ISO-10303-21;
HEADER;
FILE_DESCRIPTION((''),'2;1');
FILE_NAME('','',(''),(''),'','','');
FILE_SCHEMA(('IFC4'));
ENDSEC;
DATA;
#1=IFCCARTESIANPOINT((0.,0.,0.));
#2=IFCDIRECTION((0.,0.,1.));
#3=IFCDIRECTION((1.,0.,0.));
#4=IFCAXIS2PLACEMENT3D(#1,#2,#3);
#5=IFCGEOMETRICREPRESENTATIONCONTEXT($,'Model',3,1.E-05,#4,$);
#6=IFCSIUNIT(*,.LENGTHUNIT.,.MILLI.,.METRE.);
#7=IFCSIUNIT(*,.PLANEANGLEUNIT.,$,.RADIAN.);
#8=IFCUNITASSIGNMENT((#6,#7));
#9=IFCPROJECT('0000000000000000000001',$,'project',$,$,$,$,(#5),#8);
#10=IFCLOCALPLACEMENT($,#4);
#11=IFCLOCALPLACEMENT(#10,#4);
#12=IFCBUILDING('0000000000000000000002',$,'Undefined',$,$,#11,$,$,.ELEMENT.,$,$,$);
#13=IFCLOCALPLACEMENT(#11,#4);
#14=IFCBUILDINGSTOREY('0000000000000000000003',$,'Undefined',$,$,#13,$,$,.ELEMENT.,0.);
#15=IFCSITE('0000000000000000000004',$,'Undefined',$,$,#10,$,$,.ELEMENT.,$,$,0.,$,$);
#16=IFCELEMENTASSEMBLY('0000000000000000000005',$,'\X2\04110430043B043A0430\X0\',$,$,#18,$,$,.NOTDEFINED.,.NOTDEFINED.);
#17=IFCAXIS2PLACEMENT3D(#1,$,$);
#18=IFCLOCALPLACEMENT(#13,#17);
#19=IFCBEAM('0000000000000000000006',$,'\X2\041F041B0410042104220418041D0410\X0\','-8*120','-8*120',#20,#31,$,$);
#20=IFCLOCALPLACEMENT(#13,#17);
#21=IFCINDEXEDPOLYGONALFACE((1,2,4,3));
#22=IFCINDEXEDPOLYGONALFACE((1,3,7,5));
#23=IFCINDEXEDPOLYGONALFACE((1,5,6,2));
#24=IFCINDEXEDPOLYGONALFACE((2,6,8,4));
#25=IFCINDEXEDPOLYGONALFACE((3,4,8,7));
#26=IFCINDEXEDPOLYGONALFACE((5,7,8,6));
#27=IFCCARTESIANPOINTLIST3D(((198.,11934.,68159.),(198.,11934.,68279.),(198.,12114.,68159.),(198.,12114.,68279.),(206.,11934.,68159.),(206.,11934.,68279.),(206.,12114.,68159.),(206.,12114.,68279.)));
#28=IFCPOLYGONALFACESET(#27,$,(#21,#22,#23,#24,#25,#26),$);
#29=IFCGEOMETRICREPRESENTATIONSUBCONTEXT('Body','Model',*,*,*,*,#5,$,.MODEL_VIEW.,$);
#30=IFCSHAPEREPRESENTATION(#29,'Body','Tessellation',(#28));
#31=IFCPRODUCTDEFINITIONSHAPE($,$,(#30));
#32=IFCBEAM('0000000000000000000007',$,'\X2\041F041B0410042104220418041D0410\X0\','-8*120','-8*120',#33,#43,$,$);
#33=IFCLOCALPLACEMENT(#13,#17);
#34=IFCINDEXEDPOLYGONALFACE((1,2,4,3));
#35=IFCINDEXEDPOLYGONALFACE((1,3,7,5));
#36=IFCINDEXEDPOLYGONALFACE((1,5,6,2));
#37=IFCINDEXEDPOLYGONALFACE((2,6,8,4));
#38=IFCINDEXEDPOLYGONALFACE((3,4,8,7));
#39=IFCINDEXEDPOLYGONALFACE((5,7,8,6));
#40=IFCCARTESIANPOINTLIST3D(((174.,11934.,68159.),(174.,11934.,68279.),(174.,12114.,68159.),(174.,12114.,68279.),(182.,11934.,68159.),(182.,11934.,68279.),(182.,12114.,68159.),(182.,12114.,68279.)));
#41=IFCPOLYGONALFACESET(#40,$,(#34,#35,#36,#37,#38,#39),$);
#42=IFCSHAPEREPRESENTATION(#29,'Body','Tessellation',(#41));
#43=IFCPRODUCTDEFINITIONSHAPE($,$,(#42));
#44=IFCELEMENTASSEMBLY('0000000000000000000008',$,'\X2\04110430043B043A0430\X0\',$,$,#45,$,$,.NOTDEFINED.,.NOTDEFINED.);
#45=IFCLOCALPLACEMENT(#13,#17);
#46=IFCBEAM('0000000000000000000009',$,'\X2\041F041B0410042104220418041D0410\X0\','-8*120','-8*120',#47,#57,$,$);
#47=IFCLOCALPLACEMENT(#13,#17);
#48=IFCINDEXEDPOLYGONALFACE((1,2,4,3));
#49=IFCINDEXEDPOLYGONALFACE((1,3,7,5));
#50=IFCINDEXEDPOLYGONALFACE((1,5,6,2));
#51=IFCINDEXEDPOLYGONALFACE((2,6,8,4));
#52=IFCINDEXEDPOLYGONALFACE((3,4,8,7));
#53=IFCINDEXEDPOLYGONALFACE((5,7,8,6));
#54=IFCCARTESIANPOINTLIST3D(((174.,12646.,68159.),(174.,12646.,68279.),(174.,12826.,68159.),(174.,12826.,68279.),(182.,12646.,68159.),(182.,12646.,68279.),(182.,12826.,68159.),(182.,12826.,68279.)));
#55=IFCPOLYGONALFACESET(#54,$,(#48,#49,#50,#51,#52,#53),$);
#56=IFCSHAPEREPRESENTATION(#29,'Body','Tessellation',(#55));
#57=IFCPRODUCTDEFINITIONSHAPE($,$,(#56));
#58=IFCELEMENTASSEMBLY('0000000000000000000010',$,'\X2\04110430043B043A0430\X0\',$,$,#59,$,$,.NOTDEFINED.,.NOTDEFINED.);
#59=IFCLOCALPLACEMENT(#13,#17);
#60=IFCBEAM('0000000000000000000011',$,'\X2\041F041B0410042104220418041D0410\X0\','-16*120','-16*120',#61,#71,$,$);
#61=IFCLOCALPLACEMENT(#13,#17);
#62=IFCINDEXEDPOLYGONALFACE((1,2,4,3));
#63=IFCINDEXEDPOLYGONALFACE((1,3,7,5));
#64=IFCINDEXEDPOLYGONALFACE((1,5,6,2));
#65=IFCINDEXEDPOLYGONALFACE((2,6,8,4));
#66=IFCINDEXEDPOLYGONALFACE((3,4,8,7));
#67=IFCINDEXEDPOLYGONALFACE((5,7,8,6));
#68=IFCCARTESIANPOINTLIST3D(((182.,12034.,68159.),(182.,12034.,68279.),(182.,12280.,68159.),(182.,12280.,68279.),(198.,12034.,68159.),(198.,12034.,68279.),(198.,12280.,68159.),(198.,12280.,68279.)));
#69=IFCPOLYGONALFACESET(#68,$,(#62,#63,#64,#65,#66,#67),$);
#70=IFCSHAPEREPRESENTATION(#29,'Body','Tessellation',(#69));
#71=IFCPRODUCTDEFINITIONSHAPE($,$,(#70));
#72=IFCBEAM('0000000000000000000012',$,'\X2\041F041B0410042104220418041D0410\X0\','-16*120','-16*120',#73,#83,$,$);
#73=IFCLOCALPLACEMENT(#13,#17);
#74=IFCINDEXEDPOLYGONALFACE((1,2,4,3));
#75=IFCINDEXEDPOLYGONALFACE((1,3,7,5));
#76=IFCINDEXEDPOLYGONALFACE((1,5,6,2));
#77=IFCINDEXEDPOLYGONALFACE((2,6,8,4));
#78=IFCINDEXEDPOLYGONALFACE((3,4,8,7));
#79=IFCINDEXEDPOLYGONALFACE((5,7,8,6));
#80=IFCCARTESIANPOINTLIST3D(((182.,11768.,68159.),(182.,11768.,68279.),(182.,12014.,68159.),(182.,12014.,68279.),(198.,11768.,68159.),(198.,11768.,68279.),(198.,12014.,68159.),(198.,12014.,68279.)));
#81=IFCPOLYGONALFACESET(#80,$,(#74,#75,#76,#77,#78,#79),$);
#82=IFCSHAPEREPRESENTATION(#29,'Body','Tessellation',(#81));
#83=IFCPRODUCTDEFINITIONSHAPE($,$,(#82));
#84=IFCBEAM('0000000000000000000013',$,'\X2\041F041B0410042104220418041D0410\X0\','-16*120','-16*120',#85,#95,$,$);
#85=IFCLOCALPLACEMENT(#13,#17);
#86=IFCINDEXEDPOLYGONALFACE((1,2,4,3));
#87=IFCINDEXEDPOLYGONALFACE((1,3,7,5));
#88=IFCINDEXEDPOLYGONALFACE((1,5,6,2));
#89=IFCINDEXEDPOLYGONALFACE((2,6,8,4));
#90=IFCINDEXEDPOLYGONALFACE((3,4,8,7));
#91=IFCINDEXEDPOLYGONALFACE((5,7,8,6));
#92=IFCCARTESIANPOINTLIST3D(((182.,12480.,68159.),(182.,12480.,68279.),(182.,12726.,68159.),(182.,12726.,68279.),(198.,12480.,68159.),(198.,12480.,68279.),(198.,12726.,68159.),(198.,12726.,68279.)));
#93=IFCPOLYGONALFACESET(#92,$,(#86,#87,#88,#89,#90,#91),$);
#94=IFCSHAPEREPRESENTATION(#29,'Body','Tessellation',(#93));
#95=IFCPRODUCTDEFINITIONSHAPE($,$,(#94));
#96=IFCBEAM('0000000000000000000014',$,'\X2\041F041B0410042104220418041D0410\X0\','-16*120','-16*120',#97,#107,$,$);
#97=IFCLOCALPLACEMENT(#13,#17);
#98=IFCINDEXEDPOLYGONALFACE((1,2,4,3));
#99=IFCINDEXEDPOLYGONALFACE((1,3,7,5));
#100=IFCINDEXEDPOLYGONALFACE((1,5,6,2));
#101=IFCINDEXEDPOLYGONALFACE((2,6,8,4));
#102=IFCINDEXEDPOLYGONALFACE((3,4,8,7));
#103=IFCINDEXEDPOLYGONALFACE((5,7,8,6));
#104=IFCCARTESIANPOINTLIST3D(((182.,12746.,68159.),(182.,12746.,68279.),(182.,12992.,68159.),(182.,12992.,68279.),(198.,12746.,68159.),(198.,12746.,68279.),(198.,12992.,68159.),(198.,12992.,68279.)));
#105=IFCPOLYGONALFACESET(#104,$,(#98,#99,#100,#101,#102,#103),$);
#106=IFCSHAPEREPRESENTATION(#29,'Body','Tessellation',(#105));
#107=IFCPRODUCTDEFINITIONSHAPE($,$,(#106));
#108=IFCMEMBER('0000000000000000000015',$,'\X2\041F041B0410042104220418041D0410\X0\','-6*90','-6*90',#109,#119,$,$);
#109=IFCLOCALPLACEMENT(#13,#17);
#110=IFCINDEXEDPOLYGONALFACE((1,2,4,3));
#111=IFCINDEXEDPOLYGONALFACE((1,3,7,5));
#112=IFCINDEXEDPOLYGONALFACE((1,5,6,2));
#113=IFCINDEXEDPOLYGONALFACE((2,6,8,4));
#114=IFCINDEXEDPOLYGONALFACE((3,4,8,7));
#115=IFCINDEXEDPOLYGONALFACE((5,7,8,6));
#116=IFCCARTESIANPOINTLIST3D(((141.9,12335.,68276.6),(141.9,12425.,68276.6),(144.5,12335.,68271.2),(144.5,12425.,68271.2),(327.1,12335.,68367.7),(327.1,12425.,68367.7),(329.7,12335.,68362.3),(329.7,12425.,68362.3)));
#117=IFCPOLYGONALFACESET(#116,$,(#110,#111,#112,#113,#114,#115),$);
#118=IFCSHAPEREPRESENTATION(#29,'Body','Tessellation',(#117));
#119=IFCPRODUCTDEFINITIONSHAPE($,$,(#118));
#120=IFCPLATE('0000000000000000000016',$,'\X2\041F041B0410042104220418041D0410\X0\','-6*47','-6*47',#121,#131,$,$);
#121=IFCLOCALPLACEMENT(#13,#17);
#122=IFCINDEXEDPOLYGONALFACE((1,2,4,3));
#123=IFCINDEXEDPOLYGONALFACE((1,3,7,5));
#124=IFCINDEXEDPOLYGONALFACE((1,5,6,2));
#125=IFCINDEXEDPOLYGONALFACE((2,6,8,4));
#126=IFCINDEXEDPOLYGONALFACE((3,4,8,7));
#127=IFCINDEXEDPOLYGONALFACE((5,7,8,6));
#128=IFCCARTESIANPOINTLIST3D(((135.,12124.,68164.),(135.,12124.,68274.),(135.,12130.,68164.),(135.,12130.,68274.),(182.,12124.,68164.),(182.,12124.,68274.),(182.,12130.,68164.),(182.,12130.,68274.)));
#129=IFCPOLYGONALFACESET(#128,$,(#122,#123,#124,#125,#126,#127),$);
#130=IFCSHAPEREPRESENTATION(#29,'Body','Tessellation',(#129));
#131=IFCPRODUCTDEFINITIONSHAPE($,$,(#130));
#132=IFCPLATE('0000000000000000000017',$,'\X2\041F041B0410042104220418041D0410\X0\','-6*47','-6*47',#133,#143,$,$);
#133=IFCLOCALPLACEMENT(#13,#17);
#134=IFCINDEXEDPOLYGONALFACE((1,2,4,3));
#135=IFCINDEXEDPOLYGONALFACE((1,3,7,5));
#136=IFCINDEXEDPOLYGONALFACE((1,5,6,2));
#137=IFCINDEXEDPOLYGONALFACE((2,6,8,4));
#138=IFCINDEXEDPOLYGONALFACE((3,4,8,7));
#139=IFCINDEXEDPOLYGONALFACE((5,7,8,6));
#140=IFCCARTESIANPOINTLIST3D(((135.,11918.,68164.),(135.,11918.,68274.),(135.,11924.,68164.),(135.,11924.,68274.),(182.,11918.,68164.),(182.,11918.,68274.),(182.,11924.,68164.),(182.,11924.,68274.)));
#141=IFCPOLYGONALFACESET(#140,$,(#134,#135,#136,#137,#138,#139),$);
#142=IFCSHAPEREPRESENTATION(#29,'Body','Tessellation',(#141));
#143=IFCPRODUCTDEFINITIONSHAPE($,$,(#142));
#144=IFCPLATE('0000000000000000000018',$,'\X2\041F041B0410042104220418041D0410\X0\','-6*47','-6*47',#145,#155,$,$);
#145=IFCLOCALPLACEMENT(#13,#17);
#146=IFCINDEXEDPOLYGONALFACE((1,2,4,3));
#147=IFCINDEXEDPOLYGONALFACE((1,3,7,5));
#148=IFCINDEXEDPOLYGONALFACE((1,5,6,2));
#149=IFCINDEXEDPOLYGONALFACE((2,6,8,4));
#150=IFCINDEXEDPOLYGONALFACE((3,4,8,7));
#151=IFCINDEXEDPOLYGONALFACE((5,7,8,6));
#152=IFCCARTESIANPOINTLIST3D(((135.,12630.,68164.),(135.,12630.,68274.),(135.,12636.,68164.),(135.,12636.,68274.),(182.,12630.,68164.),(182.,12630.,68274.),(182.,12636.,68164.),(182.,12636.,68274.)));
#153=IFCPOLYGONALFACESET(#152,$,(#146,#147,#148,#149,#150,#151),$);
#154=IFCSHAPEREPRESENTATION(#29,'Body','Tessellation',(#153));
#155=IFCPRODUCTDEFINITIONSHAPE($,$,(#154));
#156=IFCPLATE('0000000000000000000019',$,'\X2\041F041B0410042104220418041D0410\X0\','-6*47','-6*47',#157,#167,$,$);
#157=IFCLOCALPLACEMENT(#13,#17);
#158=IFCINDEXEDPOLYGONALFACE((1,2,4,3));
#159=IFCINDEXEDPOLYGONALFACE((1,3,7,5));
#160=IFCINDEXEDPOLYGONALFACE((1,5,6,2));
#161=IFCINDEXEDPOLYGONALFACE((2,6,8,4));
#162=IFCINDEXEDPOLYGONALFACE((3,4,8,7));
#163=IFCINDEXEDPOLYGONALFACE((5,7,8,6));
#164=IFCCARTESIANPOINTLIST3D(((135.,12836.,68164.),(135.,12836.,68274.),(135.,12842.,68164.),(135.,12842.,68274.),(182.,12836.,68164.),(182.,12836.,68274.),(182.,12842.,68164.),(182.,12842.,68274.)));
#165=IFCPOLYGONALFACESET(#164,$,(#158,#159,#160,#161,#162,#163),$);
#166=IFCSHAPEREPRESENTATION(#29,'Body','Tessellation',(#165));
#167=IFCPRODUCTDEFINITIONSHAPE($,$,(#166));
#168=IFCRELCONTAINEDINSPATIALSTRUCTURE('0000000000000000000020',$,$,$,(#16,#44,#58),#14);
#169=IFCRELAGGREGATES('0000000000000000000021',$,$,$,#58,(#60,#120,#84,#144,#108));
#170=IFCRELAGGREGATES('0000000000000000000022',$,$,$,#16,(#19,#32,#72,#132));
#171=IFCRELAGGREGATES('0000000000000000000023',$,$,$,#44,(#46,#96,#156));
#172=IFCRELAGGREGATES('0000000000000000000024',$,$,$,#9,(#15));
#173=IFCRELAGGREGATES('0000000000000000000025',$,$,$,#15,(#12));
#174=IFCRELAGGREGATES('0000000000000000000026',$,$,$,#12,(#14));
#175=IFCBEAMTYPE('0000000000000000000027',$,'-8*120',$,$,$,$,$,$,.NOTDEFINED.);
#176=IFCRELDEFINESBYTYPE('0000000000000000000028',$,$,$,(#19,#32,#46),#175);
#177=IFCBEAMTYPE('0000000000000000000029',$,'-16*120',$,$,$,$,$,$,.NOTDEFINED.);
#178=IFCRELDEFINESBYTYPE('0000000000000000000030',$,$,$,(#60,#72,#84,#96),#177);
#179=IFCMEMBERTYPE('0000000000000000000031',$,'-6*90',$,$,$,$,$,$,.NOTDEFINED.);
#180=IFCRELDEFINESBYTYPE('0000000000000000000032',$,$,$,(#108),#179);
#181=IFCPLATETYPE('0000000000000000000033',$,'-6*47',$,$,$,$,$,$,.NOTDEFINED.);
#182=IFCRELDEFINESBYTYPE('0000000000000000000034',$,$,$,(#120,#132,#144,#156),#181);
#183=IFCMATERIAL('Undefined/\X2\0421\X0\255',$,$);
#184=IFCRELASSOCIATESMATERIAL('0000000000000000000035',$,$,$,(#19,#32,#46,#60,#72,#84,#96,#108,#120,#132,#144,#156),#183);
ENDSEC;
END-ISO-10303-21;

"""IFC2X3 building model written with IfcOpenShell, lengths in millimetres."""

from ifc_helpers import new_model, si_unit, frame, origin_with_axes, origin_2d_with_axis, place, context, subcontext, project, spatial, polyline, rectangle, outline, extrude, boolean, material, type_object, element, aggregate, save


model = new_model("IFC2X3")

# Units and contexts
model_context = context("Model", 3, precision=1e-05, world=origin_with_axes())
body_context = subcontext(model_context, "Body", "Model", "MODEL_VIEW")
ifc_project = project(units=[si_unit("LENGTHUNIT", "METRE", prefix="MILLI"), si_unit("PLANEANGLEUNIT", "RADIAN")], contexts=[model_context])

# Site, building, storey
site_placement = place(None, origin_with_axes())
site = spatial("IfcSite", under=ifc_project, at=site_placement, Name="Undefined", CompositionType="ELEMENT", RefElevation=0.0)
building_placement = place(site_placement, origin_with_axes())
building = spatial("IfcBuilding", under=site, at=building_placement, Name="Undefined", CompositionType="ELEMENT")
storey_placement = place(building_placement, origin_with_axes())
storey = spatial("IfcBuildingStorey", under=building, at=storey_placement, Name="Undefined", CompositionType="ELEMENT", Elevation=0.0)

# Element assembly, beams
assembly_1_placement = place(storey_placement, origin_with_axes())
assembly_1 = element("IfcElementAssembly", 1, at=assembly_1_placement, inside=storey, Name="Балка", AssemblyPlace="NOTDEFINED", PredefinedType="NOTDEFINED")
ifc_material_1 = material(Name="Undefined/С255")
beam_type_1 = type_object("IfcBeamType", Name="-8*120", PredefinedType="NOTDEFINED")
beam_1_placement = place(assembly_1_placement, frame((202.0, 11934.0, 68219.0), z_axis=(0.0, 0.0, 1.0), x_axis=(0.0, 1.0, 0.0)))
beam_1 = element("IfcBeam", 2, at=beam_1_placement, type_object=beam_type_1, material=ifc_material_1, Name="ПЛАСТИНА", Description="-8*120", ObjectType="-8*120", context=body_context, shape_type="SweptSolid", body=[
    extrude(rectangle(XDim=8.0, YDim=120.0, at=origin_2d_with_axis()), frame((180.0, 0.0, 0.0), z_axis=(-1.0, 0.0, 0.0), x_axis=(0.0, -1.0, 0.0)), (0.0, 0.0, 1.0), 180.0),
])
beam_2_placement = place(assembly_1_placement, frame((178.0, 11934.0, 68219.0), z_axis=(0.0, 0.0, 1.0), x_axis=(0.0, 1.0, 0.0)))
beam_2 = element("IfcBeam", 3, at=beam_2_placement, type_object=beam_type_1, material=ifc_material_1, Name="ПЛАСТИНА", Description="-8*120", ObjectType="-8*120", context=body_context, shape_type="SweptSolid", body=[
    extrude(rectangle(XDim=8.0, YDim=120.0, at=origin_2d_with_axis()), frame((180.0, 0.0, 0.0), z_axis=(-1.0, 0.0, 0.0), x_axis=(0.0, -1.0, 0.0)), (0.0, 0.0, 1.0), 180.0),
])

# Element assemblies, beams
assembly_2_placement = place(storey_placement, origin_with_axes())
assembly_2 = element("IfcElementAssembly", 4, at=assembly_2_placement, inside=storey, Name="Балка", AssemblyPlace="NOTDEFINED", PredefinedType="NOTDEFINED")
beam_3_placement = place(assembly_2_placement, frame((178.0, 12826.0, 68219.0), z_axis=(0.0, 0.0, -1.0), x_axis=(0.0, -1.0, 0.0)))
beam_3 = element("IfcBeam", 5, at=beam_3_placement, type_object=beam_type_1, material=ifc_material_1, Name="ПЛАСТИНА", Description="-8*120", ObjectType="-8*120", context=body_context, shape_type="SweptSolid", body=[
    extrude(rectangle(XDim=8.0, YDim=120.0, at=origin_2d_with_axis()), frame((180.0, 0.0, 0.0), z_axis=(-1.0, 0.0, 0.0), x_axis=(0.0, -1.0, 0.0)), (0.0, 0.0, 1.0), 180.0),
])
assembly_3_placement = place(storey_placement, origin_with_axes())
assembly_3 = element("IfcElementAssembly", 6, at=assembly_3_placement, inside=storey, Name="Балка", AssemblyPlace="NOTDEFINED", PredefinedType="NOTDEFINED")
beam_type_2 = type_object("IfcBeamType", Name="-16*120", PredefinedType="NOTDEFINED")
beam_4_placement = place(assembly_3_placement, frame((190.0, 12034.0, 68219.0), z_axis=(0.0, 0.0, 1.0), x_axis=(0.0, 1.0, 0.0)))
beam_4 = element("IfcBeam", 7, at=beam_4_placement, type_object=beam_type_2, material=ifc_material_1, Name="ПЛАСТИНА", Description="-16*120", ObjectType="-16*120", context=body_context, shape_type="SweptSolid", body=[
    extrude(rectangle(XDim=16.0, YDim=120.0, at=origin_2d_with_axis()), frame((246.0, 0.0, 0.0), z_axis=(-1.0, 0.0, 0.0), x_axis=(0.0, -1.0, 0.0)), (0.0, 0.0, 1.0), 246.0),
])

# Beams
beam_5_placement = place(assembly_1_placement, frame((190.0, 11768.0, 68219.0), z_axis=(0.0, 0.0, 1.0), x_axis=(0.0, 1.0, 0.0)))
beam_5 = element("IfcBeam", 8, at=beam_5_placement, type_object=beam_type_2, material=ifc_material_1, Name="ПЛАСТИНА", Description="-16*120", ObjectType="-16*120", context=body_context, shape_type="SweptSolid", body=[
    extrude(rectangle(XDim=16.0, YDim=120.0, at=origin_2d_with_axis()), frame((246.0, 0.0, 0.0), z_axis=(-1.0, 0.0, 0.0), x_axis=(0.0, -1.0, 0.0)), (0.0, 0.0, 1.0), 246.0),
])
beam_6_placement = place(assembly_3_placement, frame((190.0, 12726.0, 68219.0), z_axis=(0.0, 0.0, -1.0), x_axis=(0.0, -1.0, 0.0)))
beam_6 = element("IfcBeam", 9, at=beam_6_placement, type_object=beam_type_2, material=ifc_material_1, Name="ПЛАСТИНА", Description="-16*120", ObjectType="-16*120", context=body_context, shape_type="SweptSolid", body=[
    extrude(rectangle(XDim=16.0, YDim=120.0, at=origin_2d_with_axis()), frame((246.0, 0.0, 0.0), z_axis=(-1.0, 0.0, 0.0), x_axis=(0.0, -1.0, 0.0)), (0.0, 0.0, 1.0), 246.0),
])
beam_7_placement = place(assembly_2_placement, frame((190.0, 12992.0, 68219.0), z_axis=(0.0, 0.0, -1.0), x_axis=(0.0, -1.0, 0.0)))
beam_7 = element("IfcBeam", 10, at=beam_7_placement, type_object=beam_type_2, material=ifc_material_1, Name="ПЛАСТИНА", Description="-16*120", ObjectType="-16*120", context=body_context, shape_type="SweptSolid", body=[
    extrude(rectangle(XDim=16.0, YDim=120.0, at=origin_2d_with_axis()), frame((246.0, 0.0, 0.0), z_axis=(-1.0, 0.0, 0.0), x_axis=(0.0, -1.0, 0.0)), (0.0, 0.0, 1.0), 246.0),
])

# Member
member_type = type_object("IfcMemberType", Name="-6*90", PredefinedType="NOTDEFINED")
member_placement = place(assembly_3_placement, frame((143.2, 12380.0, 68273.9), z_axis=(0.0, -1.0, 0.0), x_axis=(0.897399, 0.0, 0.441221)))
member = element("IfcMember", 11, at=member_placement, type_object=member_type, material=ifc_material_1, Name="ПЛАСТИНА", Description="-6*90", ObjectType="-6*90", context=body_context, shape_type="SweptSolid", body=[
    extrude(rectangle(XDim=6.0, YDim=90.0, at=origin_2d_with_axis()), frame((206.4, 0.0, 0.0), z_axis=(-1.0, 0.0, 0.0), x_axis=(0.0, -1.0, 0.0)), (0.0, 0.0, 1.0), 206.4),
])

# Plates
plate_type = type_object("IfcPlateType", Name="-6*47", PredefinedType="NOTDEFINED")
plate_1_placement = place(assembly_3_placement, frame((135.0, 12127.0, 68274.0), z_axis=(0.0, -1.0, 0.0), x_axis=(0.0, 0.0, -1.0)))
plate_1 = element("IfcPlate", 12, at=plate_1_placement, type_object=plate_type, material=ifc_material_1, Name="ПЛАСТИНА", Description="-6*47", ObjectType="-6*47", context=body_context, shape_type="CSG", body=[
    boolean("DIFFERENCE", extrude(outline(polyline([(0.0, 0.0), (110.0, 0.0), (110.0, 110.0), (0.0, 110.0), (0.0, 0.0)])), frame((0.0, 0.0, -3.0), z_axis=(0.0, 0.0, 1.0), x_axis=(1.0, 0.0, 0.0)), (0.0, 0.0, 1.0), 6.0), extrude(rectangle(XDim=26.0, YDim=130.0, at=origin_2d_with_axis()), frame((55.0, 47.0, 0.0), z_axis=(0.0, 1.0, 0.0), x_axis=(0.0, 0.0, -1.0)), (0.0, 0.0, 1.0), 66.0)),
])
plate_2_placement = place(assembly_1_placement, frame((135.0, 11921.0, 68164.0), z_axis=(0.0, 1.0, 0.0), x_axis=(0.0, 0.0, 1.0)))
plate_2 = element("IfcPlate", 13, at=plate_2_placement, type_object=plate_type, material=ifc_material_1, Name="ПЛАСТИНА", Description="-6*47", ObjectType="-6*47", context=body_context, shape_type="CSG", body=[
    boolean("DIFFERENCE", extrude(outline(polyline([(0.0, 0.0), (110.0, 0.0), (110.0, 110.0), (0.0, 110.0), (0.0, 0.0)])), frame((0.0, 0.0, -3.0), z_axis=(0.0, 0.0, 1.0), x_axis=(1.0, 0.0, 0.0)), (0.0, 0.0, 1.0), 6.0), extrude(rectangle(XDim=26.0, YDim=130.0, at=origin_2d_with_axis()), frame((55.0, 47.0, 0.0), z_axis=(0.0, 1.0, 0.0), x_axis=(0.0, 0.0, -1.0)), (0.0, 0.0, 1.0), 66.0)),
])
plate_3_placement = place(assembly_3_placement, frame((135.0, 12633.0, 68164.0), z_axis=(0.0, 1.0, 0.0), x_axis=(0.0, 0.0, 1.0)))
plate_3 = element("IfcPlate", 14, at=plate_3_placement, type_object=plate_type, material=ifc_material_1, Name="ПЛАСТИНА", Description="-6*47", ObjectType="-6*47", context=body_context, shape_type="CSG", body=[
    boolean("DIFFERENCE", extrude(outline(polyline([(0.0, 0.0), (110.0, 0.0), (110.0, 110.0), (0.0, 110.0), (0.0, 0.0)])), frame((0.0, 0.0, -3.0), z_axis=(0.0, 0.0, 1.0), x_axis=(1.0, 0.0, 0.0)), (0.0, 0.0, 1.0), 6.0), extrude(rectangle(XDim=26.0, YDim=130.0, at=origin_2d_with_axis()), frame((55.0, 47.0, 0.0), z_axis=(0.0, 1.0, 0.0), x_axis=(0.0, 0.0, -1.0)), (0.0, 0.0, 1.0), 66.0)),
])
aggregate(assembly_3, [beam_4, plate_1, beam_6, plate_3, member])
plate_4_placement = place(assembly_2_placement, frame((135.0, 12839.0, 68274.0), z_axis=(0.0, -1.0, 0.0), x_axis=(0.0, 0.0, -1.0)))
plate_4 = element("IfcPlate", 15, at=plate_4_placement, type_object=plate_type, material=ifc_material_1, Name="ПЛАСТИНА", Description="-6*47", ObjectType="-6*47", context=body_context, shape_type="CSG", body=[
    boolean("DIFFERENCE", extrude(outline(polyline([(0.0, 0.0), (110.0, 0.0), (110.0, 110.0), (0.0, 110.0), (0.0, 0.0)])), frame((0.0, 0.0, -3.0), z_axis=(0.0, 0.0, 1.0), x_axis=(1.0, 0.0, 0.0)), (0.0, 0.0, 1.0), 6.0), extrude(rectangle(XDim=26.0, YDim=130.0, at=origin_2d_with_axis()), frame((55.0, 47.0, 0.0), z_axis=(0.0, 1.0, 0.0), x_axis=(0.0, 0.0, -1.0)), (0.0, 0.0, 1.0), 66.0)),
])

aggregate(assembly_1, [beam_1, beam_2, beam_5, plate_2])
aggregate(assembly_2, [beam_3, beam_7, plate_4])

save(model, "model.ifc")
